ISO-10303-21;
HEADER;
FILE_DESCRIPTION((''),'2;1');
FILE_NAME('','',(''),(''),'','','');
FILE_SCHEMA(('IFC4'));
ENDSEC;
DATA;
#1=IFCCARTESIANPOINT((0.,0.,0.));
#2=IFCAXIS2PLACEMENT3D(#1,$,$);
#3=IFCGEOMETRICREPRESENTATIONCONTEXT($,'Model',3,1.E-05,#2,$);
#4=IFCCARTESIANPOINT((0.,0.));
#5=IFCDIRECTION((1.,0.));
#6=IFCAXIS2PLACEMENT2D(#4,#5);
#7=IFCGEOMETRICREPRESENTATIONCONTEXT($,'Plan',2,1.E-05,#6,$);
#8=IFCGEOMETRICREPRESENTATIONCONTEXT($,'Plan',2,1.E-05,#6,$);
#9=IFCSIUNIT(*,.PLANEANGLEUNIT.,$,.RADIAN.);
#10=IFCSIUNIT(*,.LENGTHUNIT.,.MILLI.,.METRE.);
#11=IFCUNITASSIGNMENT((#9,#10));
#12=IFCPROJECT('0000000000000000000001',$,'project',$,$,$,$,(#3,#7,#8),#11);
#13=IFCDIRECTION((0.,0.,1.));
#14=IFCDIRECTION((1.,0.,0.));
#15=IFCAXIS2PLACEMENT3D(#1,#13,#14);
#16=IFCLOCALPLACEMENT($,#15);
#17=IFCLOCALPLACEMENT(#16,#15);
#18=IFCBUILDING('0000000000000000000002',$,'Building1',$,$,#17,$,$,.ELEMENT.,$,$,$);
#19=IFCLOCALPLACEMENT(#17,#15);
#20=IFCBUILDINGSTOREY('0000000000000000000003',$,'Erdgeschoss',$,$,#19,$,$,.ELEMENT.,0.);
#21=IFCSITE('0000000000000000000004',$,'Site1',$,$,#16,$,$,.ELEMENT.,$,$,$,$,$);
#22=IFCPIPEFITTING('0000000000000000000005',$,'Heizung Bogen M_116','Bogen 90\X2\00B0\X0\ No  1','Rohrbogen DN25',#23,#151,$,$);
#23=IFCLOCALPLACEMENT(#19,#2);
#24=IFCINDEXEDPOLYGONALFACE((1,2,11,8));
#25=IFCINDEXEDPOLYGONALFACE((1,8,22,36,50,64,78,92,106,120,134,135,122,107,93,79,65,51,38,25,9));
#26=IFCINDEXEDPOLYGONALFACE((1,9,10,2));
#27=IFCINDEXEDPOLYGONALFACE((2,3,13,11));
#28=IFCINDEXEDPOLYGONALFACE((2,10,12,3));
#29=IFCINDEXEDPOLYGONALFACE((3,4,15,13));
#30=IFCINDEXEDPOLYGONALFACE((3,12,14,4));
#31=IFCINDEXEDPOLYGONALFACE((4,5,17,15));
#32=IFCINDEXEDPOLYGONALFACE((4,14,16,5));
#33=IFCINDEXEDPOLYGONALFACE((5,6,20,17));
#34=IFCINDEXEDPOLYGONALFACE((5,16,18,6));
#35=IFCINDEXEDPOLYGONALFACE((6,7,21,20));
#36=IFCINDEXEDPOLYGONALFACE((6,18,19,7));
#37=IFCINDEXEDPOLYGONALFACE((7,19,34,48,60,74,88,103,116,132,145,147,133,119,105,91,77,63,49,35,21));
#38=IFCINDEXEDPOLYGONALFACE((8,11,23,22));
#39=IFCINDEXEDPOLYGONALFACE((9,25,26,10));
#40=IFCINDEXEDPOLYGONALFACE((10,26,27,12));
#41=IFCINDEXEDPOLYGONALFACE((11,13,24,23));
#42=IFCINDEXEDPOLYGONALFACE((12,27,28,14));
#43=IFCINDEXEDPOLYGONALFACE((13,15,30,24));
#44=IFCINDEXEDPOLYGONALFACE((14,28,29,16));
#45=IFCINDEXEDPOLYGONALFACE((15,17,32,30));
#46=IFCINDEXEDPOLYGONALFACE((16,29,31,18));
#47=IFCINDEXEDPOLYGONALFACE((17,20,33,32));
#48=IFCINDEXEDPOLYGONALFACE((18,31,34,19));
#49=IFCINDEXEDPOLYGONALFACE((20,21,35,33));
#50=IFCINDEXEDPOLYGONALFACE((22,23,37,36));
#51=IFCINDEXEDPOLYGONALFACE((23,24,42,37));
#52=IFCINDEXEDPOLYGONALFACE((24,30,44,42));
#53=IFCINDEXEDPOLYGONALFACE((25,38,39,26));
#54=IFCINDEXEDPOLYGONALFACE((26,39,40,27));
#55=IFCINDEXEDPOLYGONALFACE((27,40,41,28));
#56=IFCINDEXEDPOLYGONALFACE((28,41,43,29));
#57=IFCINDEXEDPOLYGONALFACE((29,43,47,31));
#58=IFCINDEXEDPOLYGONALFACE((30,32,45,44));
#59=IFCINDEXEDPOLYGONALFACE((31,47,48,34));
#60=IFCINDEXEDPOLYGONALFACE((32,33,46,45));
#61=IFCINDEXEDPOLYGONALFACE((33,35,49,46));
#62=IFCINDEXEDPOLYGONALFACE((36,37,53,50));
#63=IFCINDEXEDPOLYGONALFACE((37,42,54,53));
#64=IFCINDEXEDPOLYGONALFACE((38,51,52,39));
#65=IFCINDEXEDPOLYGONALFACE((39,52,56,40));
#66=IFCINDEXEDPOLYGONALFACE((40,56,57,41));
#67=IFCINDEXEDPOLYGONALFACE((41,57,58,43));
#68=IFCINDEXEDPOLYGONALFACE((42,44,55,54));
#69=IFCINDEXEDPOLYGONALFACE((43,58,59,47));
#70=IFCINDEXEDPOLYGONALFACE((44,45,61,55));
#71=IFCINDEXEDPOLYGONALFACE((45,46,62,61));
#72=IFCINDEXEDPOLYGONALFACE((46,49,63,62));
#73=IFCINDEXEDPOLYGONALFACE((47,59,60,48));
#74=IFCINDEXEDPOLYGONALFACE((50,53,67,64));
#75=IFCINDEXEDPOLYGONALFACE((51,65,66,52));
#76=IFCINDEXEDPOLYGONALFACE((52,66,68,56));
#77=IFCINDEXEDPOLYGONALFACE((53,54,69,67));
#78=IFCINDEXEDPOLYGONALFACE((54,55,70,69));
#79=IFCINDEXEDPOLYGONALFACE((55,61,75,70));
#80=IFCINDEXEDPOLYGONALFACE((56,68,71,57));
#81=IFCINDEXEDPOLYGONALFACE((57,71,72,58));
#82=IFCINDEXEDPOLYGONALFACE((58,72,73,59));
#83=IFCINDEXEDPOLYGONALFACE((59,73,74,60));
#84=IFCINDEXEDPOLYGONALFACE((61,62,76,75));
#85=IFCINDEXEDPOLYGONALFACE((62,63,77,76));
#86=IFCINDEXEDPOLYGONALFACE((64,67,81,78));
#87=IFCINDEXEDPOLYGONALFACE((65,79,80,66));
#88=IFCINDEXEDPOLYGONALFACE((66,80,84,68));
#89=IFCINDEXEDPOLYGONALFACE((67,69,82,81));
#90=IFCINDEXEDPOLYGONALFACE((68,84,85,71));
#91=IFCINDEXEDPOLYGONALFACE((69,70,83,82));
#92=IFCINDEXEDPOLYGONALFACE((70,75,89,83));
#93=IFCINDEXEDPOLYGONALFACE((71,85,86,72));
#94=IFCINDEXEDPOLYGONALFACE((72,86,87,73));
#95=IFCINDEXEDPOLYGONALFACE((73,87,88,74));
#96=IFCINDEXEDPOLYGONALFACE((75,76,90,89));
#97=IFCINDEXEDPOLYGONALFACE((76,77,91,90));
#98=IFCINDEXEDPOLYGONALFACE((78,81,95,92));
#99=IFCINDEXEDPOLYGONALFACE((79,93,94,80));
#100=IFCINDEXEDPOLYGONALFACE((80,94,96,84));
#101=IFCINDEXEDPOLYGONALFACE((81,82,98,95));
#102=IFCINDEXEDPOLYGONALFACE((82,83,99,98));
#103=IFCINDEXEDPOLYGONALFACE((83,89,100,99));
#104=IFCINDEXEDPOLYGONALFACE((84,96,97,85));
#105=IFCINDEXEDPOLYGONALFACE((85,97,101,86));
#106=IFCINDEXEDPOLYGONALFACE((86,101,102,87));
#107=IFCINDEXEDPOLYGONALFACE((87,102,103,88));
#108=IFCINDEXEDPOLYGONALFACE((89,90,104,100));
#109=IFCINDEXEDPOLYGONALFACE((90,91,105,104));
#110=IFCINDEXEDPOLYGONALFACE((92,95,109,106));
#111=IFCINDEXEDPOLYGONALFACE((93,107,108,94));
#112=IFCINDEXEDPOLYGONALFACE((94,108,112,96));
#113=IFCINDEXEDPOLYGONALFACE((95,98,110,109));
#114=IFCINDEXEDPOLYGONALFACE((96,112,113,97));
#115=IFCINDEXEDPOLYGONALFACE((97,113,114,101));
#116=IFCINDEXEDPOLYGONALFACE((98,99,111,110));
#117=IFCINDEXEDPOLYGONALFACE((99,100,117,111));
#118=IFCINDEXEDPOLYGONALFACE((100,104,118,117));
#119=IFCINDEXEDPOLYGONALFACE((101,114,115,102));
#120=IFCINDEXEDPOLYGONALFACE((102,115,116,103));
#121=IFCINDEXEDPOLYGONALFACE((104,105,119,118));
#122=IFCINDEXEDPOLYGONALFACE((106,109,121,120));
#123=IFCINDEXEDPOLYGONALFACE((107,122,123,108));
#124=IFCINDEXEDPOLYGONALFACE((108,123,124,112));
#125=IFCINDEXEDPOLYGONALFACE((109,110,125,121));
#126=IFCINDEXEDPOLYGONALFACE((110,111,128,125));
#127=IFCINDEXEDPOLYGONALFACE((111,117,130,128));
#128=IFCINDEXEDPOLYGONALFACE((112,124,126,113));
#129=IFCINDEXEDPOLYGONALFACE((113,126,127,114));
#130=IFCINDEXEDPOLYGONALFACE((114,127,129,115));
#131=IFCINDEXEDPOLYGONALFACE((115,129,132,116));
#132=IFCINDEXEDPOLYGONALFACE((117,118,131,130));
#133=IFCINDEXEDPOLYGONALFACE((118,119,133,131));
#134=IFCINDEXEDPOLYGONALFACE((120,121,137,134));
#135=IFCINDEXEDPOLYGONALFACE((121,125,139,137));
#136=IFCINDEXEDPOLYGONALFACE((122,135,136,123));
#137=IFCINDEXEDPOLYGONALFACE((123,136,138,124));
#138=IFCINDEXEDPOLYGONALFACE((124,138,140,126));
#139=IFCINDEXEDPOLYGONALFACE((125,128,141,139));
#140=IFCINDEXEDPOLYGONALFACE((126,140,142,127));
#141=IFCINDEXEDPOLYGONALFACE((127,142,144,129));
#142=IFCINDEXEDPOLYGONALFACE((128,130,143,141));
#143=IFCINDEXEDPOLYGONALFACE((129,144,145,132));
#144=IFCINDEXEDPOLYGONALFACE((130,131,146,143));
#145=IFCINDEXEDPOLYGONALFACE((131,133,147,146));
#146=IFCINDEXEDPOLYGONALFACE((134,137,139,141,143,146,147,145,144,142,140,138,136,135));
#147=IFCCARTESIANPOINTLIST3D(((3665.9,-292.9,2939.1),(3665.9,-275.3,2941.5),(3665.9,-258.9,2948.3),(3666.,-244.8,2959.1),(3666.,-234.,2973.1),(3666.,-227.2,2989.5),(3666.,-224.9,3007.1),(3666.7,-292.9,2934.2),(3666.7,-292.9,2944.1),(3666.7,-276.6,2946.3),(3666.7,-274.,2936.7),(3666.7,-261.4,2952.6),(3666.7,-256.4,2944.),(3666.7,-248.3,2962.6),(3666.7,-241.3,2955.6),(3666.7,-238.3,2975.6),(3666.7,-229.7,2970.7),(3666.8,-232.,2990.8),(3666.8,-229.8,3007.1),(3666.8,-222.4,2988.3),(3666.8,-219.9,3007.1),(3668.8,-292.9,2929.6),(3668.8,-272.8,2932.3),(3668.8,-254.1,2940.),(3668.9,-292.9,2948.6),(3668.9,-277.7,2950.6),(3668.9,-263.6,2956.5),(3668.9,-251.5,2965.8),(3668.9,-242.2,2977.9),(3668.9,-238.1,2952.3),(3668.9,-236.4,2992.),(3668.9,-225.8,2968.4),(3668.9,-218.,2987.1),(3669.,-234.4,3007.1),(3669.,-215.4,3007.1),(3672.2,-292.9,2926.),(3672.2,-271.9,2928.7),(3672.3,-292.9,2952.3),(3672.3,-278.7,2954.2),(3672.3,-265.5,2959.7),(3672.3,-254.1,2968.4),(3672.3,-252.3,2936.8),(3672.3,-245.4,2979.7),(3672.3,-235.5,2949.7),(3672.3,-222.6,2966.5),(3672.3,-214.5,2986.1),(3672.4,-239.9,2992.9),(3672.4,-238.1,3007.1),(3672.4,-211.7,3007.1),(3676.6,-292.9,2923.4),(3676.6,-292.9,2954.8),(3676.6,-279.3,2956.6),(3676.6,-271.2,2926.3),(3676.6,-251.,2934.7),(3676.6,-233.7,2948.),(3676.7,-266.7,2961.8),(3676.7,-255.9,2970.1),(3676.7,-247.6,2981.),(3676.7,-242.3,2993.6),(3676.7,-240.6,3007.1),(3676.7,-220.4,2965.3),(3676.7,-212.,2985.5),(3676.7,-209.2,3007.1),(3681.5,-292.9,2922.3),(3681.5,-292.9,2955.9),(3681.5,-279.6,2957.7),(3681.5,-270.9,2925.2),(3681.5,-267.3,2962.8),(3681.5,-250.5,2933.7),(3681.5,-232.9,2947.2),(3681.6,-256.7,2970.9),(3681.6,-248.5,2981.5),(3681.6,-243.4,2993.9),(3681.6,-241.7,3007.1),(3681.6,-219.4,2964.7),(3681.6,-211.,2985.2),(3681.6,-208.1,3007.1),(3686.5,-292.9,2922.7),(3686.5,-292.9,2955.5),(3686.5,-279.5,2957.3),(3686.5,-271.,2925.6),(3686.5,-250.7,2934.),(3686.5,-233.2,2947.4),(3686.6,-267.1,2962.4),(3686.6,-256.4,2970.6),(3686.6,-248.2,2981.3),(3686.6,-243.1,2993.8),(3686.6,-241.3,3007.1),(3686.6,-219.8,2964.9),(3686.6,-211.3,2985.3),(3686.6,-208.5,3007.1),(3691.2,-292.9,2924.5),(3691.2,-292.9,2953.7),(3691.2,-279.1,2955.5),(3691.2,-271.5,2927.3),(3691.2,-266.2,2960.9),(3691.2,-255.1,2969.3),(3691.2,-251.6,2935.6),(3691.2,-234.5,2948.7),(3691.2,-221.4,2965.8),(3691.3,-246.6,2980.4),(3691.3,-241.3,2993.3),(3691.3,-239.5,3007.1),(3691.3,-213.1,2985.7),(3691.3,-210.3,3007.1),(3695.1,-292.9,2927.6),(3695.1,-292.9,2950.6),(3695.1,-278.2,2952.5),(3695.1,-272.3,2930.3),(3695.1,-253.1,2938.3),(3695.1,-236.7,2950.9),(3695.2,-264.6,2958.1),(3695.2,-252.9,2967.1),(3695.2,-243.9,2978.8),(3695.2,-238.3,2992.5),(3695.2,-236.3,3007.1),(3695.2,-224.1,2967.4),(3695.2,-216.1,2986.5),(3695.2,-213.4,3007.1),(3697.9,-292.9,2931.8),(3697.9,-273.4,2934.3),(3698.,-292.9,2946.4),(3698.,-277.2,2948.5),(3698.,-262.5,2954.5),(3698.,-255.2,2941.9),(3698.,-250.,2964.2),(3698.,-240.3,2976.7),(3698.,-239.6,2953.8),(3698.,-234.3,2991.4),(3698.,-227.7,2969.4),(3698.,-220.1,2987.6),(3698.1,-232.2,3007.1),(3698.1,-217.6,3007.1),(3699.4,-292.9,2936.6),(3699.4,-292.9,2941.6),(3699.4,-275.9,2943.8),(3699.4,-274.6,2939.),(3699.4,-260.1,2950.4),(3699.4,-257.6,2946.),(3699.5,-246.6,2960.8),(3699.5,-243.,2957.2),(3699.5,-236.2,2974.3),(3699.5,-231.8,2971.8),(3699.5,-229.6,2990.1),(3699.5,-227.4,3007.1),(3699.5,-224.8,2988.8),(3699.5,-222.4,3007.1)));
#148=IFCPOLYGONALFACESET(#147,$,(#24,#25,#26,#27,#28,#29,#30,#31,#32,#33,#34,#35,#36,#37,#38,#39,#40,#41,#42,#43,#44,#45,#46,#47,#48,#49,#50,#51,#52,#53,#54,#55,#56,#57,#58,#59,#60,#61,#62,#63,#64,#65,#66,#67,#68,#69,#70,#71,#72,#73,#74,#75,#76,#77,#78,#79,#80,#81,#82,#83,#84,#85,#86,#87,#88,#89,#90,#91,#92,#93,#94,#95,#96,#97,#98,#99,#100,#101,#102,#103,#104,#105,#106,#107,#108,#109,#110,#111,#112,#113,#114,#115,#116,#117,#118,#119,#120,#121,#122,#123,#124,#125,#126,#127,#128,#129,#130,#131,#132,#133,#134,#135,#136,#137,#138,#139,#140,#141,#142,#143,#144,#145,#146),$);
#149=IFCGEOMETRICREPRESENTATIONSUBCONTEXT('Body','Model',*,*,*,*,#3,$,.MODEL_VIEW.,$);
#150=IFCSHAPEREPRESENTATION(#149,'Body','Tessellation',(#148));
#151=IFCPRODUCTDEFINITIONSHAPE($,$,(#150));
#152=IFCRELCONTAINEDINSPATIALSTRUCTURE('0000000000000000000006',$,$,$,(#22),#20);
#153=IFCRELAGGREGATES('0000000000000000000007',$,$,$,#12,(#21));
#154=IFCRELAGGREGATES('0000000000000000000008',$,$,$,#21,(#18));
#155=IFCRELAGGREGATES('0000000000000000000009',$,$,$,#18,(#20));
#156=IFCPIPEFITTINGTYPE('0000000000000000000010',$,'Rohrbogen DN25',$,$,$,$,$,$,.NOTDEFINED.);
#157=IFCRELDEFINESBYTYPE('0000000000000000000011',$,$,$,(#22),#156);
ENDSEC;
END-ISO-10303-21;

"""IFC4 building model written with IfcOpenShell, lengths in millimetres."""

from ifc_helpers import new_model, entity, si_unit, frame, origin, origin_with_axes, origin_2d_with_axis, place, context, subcontext, project, spatial, source, transform, mapped, type_object, element, save


model = new_model("IFC4")

# Units and contexts
model_context = context("Model", 3, precision=1e-05, world=origin())
plan_context_1 = context("Plan", 2, precision=1e-05, world=origin_2d_with_axis())
plan_context_2 = context("Plan", 2, precision=1e-05, world=origin_2d_with_axis())
body_context = subcontext(model_context, "Body", "Model", "MODEL_VIEW")
ifc_project = project(units=[si_unit("PLANEANGLEUNIT", "RADIAN"), si_unit("LENGTHUNIT", "METRE", prefix="MILLI")], contexts=[model_context, plan_context_1, plan_context_2])

# Site, building, storey
site_placement = place(None, origin_with_axes())
site = spatial("IfcSite", under=ifc_project, at=site_placement, Name="Site1", CompositionType="ELEMENT")
building_placement = place(site_placement, origin_with_axes())
building = spatial("IfcBuilding", under=site, at=building_placement, Name="Building1", CompositionType="ELEMENT")
storey_placement = place(building_placement, origin_with_axes())
storey = spatial("IfcBuildingStorey", under=building, at=storey_placement, Name="Erdgeschoss", CompositionType="ELEMENT", Elevation=0.0)

# Pipe fitting
pipe_fitting_type_1 = type_object("IfcPipeFittingType", Name="Rohrbogen DN25", PredefinedType="NOTDEFINED")
shared_shape_1 = source(origin_with_axes(), body_context, "Body", "SolidModel", [
    entity("IfcRevolvedAreaSolid", entity("IfcCircleProfileDef", "AREA", None, entity("IfcAxis2Placement2D", entity("IfcCartesianPoint", [0.0, 0.0]), entity("IfcDirection", [1.0, 0.0])), 16.9), entity("IfcAxis2Placement3D", entity("IfcCartesianPoint", [-42.4, 0.0, -25.6]), entity("IfcDirection", [1.0, 0.0, 0.0]), entity("IfcDirection", [0.0, 0.999999, 0.00173])), entity("IfcAxis1Placement", entity("IfcCartesianPoint", [0.0, 68.0, 0.0]), entity("IfcDirection", [-1.0, 0.0, 0.0])), 1.570796),
])
pipe_fitting_1_placement = place(storey_placement, frame((3682.8, -250.5, 2964.7), z_axis=(0.0, 0.0, 1.0), x_axis=(1.0, 0.0, 0.0)))
element("IfcPipeFitting", 1, at=pipe_fitting_1_placement, inside=storey, type_object=pipe_fitting_type_1, Name="Heizung Bogen M_116", Description="Bogen 90° No  1", ObjectType="Rohrbogen DN25", context=body_context, shape_type="MappedRepresentation", body=[
    mapped(shared_shape_1, transform((0.0, 0.0, 0.0), x_axis=(0.0, 1.0, 0.0), y_axis=(-1.0, 0.0, 0.0), z_axis=(0.0, 0.0, 1.0), scale=1.0)),
])

save(model, "model.ifc")
